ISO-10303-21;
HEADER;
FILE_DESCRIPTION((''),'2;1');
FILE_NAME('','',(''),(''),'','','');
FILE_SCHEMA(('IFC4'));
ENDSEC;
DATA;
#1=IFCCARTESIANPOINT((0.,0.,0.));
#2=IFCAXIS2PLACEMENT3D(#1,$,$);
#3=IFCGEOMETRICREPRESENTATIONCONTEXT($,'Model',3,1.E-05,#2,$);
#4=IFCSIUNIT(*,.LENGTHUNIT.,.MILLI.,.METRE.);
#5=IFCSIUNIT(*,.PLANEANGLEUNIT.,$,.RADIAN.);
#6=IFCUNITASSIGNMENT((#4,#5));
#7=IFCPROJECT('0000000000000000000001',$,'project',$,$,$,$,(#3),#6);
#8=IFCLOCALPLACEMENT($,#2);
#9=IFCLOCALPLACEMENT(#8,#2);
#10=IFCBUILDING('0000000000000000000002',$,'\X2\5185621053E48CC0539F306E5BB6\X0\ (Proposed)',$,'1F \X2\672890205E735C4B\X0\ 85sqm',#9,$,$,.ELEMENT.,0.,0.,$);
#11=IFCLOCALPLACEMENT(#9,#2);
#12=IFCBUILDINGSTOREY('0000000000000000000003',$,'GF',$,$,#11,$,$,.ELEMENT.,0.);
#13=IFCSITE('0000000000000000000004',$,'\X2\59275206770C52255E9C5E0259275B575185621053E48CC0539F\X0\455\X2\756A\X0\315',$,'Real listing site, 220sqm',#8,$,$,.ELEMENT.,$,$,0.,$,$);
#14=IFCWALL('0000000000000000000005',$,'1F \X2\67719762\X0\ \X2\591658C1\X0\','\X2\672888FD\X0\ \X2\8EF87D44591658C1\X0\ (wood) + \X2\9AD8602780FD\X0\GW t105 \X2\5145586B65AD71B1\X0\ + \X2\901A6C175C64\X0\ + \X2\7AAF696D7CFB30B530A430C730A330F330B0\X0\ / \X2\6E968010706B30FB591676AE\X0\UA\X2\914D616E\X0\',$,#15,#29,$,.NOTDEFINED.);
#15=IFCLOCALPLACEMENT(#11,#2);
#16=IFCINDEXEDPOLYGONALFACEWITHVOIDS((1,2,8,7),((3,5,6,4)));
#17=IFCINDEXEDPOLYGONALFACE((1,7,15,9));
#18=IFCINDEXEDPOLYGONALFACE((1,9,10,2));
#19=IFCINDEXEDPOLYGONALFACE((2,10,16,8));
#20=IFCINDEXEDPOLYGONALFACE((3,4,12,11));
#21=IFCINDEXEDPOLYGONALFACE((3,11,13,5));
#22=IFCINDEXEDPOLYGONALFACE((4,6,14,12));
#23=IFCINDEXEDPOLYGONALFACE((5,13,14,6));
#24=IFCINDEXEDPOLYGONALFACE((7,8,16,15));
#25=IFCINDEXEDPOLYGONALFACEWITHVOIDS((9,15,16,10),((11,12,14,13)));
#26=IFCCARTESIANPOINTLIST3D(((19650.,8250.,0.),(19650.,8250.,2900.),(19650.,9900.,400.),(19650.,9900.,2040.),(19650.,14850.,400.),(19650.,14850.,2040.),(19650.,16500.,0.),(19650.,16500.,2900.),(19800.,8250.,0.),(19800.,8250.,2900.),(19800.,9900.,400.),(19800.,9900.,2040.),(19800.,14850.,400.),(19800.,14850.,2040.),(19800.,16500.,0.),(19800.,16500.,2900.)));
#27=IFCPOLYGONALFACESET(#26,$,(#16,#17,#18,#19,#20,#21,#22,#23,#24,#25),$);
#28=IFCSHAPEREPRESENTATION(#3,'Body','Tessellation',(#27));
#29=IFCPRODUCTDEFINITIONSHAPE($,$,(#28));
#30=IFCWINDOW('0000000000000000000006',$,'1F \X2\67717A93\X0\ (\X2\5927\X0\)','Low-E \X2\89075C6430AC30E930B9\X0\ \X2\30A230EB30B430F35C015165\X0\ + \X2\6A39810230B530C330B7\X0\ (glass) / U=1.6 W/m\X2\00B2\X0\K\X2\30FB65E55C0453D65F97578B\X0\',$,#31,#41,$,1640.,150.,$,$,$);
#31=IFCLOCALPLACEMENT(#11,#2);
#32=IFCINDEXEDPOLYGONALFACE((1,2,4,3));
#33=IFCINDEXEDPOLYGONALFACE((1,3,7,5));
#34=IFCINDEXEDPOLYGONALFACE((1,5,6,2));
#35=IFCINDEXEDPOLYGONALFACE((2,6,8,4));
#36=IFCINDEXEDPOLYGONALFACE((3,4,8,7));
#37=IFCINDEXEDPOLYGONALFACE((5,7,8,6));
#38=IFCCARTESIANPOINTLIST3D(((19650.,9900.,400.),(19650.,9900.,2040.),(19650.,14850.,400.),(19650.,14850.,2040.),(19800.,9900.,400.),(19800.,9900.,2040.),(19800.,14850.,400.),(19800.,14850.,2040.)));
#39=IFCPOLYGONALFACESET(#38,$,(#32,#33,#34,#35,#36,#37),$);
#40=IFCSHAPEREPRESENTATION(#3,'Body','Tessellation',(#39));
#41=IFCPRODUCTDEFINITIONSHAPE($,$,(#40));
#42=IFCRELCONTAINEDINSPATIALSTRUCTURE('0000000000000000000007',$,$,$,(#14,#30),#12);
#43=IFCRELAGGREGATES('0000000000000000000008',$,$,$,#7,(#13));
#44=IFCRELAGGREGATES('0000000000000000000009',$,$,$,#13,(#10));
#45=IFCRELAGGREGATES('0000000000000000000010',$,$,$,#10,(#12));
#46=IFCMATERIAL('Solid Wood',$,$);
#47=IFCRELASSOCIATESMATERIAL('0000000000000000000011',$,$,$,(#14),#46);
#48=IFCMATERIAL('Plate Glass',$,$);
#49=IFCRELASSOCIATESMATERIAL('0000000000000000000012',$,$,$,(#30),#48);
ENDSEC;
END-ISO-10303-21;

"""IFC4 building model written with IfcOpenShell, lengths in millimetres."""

from ifc_helpers import new_model, si_unit, frame, frame_2d, origin, place, context, project, spatial, rectangle, extrude, material, element, fill, save


model = new_model("IFC4")

# Units and contexts
model_context = context("Model", 3, precision=1e-05, world=origin())
ifc_project = project(units=[si_unit("LENGTHUNIT", "METRE", prefix="MILLI"), si_unit("PLANEANGLEUNIT", "RADIAN")], contexts=[model_context])

# Site, building, storey
site_placement = place(None, origin())
site = spatial("IfcSite", under=ifc_project, at=site_placement, Name="大分県別府市大字内成古賀原455番315", ObjectType="Real listing site, 220sqm", CompositionType="ELEMENT", RefElevation=0.0)
building_placement = place(site_placement, origin())
building = spatial("IfcBuilding", under=site, at=building_placement, Name="内成古賀原の家 (Proposed)", ObjectType="1F 木造平屋 85sqm", CompositionType="ELEMENT", ElevationOfRefHeight=0.0, ElevationOfTerrain=0.0)
storey_placement = place(building_placement, origin())
storey = spatial("IfcBuildingStorey", under=building, at=storey_placement, Name="GF", CompositionType="ELEMENT", Elevation=0.0)

# Wall, opening, window
ifc_material_1 = material(Name="Solid Wood")
wall_1_placement = place(storey_placement, frame((9825.0, 4125.0, 0.0)))
wall_1 = element("IfcWall", 1, at=wall_1_placement, inside=storey, material=ifc_material_1, Name="1F 東面 外壁", Description="木製 軸組外壁 (wood) + 高性能GW t105 充填断熱 + 通気層 + 窯業系サイディング / 準耐火・外皮UA配慮", PredefinedType="NOTDEFINED", context=model_context, shape_type="SweptSolid", body=[
    extrude(rectangle(XDim=150.0, YDim=8250.0, at=frame_2d((75.0, 4125.0))), frame((9825.0, 4125.0, 0.0)), (0.0, 0.0, 1.0), 2900.0),
])
opening_1_placement = place(storey_placement, frame((9825.0, 4950.0, 200.0)))
opening_1 = element("IfcOpeningElement", 2, at=opening_1_placement, cuts=wall_1, PredefinedType="NOTDEFINED", context=model_context, shape_type="SweptSolid", body=[
    extrude(rectangle(XDim=150.0, YDim=4950.0, at=frame_2d((75.0, 2475.0))), frame((9825.0, 4950.0, 200.0)), (0.0, 0.0, 1.0), 1640.0),
])
ifc_material_2 = material(Name="Plate Glass")
window_1_placement = place(storey_placement, frame((9825.0, 4950.0, 200.0)))
window_1 = element("IfcWindow", 3, at=window_1_placement, inside=storey, material=ifc_material_2, Name="1F 東窓 (大)", Description="Low-E 複層ガラス アルゴン封入 + 樹脂サッシ (glass) / U=1.6 W/m²K・日射取得型", OverallHeight=1640.0, OverallWidth=150.0, context=model_context, shape_type="SweptSolid", body=[
    extrude(rectangle(XDim=150.0, YDim=4950.0, at=frame_2d((75.0, 2475.0))), frame((9825.0, 4950.0, 200.0)), (0.0, 0.0, 1.0), 1640.0),
])
fill(opening_1, window_1)

save(model, "model.ifc")
